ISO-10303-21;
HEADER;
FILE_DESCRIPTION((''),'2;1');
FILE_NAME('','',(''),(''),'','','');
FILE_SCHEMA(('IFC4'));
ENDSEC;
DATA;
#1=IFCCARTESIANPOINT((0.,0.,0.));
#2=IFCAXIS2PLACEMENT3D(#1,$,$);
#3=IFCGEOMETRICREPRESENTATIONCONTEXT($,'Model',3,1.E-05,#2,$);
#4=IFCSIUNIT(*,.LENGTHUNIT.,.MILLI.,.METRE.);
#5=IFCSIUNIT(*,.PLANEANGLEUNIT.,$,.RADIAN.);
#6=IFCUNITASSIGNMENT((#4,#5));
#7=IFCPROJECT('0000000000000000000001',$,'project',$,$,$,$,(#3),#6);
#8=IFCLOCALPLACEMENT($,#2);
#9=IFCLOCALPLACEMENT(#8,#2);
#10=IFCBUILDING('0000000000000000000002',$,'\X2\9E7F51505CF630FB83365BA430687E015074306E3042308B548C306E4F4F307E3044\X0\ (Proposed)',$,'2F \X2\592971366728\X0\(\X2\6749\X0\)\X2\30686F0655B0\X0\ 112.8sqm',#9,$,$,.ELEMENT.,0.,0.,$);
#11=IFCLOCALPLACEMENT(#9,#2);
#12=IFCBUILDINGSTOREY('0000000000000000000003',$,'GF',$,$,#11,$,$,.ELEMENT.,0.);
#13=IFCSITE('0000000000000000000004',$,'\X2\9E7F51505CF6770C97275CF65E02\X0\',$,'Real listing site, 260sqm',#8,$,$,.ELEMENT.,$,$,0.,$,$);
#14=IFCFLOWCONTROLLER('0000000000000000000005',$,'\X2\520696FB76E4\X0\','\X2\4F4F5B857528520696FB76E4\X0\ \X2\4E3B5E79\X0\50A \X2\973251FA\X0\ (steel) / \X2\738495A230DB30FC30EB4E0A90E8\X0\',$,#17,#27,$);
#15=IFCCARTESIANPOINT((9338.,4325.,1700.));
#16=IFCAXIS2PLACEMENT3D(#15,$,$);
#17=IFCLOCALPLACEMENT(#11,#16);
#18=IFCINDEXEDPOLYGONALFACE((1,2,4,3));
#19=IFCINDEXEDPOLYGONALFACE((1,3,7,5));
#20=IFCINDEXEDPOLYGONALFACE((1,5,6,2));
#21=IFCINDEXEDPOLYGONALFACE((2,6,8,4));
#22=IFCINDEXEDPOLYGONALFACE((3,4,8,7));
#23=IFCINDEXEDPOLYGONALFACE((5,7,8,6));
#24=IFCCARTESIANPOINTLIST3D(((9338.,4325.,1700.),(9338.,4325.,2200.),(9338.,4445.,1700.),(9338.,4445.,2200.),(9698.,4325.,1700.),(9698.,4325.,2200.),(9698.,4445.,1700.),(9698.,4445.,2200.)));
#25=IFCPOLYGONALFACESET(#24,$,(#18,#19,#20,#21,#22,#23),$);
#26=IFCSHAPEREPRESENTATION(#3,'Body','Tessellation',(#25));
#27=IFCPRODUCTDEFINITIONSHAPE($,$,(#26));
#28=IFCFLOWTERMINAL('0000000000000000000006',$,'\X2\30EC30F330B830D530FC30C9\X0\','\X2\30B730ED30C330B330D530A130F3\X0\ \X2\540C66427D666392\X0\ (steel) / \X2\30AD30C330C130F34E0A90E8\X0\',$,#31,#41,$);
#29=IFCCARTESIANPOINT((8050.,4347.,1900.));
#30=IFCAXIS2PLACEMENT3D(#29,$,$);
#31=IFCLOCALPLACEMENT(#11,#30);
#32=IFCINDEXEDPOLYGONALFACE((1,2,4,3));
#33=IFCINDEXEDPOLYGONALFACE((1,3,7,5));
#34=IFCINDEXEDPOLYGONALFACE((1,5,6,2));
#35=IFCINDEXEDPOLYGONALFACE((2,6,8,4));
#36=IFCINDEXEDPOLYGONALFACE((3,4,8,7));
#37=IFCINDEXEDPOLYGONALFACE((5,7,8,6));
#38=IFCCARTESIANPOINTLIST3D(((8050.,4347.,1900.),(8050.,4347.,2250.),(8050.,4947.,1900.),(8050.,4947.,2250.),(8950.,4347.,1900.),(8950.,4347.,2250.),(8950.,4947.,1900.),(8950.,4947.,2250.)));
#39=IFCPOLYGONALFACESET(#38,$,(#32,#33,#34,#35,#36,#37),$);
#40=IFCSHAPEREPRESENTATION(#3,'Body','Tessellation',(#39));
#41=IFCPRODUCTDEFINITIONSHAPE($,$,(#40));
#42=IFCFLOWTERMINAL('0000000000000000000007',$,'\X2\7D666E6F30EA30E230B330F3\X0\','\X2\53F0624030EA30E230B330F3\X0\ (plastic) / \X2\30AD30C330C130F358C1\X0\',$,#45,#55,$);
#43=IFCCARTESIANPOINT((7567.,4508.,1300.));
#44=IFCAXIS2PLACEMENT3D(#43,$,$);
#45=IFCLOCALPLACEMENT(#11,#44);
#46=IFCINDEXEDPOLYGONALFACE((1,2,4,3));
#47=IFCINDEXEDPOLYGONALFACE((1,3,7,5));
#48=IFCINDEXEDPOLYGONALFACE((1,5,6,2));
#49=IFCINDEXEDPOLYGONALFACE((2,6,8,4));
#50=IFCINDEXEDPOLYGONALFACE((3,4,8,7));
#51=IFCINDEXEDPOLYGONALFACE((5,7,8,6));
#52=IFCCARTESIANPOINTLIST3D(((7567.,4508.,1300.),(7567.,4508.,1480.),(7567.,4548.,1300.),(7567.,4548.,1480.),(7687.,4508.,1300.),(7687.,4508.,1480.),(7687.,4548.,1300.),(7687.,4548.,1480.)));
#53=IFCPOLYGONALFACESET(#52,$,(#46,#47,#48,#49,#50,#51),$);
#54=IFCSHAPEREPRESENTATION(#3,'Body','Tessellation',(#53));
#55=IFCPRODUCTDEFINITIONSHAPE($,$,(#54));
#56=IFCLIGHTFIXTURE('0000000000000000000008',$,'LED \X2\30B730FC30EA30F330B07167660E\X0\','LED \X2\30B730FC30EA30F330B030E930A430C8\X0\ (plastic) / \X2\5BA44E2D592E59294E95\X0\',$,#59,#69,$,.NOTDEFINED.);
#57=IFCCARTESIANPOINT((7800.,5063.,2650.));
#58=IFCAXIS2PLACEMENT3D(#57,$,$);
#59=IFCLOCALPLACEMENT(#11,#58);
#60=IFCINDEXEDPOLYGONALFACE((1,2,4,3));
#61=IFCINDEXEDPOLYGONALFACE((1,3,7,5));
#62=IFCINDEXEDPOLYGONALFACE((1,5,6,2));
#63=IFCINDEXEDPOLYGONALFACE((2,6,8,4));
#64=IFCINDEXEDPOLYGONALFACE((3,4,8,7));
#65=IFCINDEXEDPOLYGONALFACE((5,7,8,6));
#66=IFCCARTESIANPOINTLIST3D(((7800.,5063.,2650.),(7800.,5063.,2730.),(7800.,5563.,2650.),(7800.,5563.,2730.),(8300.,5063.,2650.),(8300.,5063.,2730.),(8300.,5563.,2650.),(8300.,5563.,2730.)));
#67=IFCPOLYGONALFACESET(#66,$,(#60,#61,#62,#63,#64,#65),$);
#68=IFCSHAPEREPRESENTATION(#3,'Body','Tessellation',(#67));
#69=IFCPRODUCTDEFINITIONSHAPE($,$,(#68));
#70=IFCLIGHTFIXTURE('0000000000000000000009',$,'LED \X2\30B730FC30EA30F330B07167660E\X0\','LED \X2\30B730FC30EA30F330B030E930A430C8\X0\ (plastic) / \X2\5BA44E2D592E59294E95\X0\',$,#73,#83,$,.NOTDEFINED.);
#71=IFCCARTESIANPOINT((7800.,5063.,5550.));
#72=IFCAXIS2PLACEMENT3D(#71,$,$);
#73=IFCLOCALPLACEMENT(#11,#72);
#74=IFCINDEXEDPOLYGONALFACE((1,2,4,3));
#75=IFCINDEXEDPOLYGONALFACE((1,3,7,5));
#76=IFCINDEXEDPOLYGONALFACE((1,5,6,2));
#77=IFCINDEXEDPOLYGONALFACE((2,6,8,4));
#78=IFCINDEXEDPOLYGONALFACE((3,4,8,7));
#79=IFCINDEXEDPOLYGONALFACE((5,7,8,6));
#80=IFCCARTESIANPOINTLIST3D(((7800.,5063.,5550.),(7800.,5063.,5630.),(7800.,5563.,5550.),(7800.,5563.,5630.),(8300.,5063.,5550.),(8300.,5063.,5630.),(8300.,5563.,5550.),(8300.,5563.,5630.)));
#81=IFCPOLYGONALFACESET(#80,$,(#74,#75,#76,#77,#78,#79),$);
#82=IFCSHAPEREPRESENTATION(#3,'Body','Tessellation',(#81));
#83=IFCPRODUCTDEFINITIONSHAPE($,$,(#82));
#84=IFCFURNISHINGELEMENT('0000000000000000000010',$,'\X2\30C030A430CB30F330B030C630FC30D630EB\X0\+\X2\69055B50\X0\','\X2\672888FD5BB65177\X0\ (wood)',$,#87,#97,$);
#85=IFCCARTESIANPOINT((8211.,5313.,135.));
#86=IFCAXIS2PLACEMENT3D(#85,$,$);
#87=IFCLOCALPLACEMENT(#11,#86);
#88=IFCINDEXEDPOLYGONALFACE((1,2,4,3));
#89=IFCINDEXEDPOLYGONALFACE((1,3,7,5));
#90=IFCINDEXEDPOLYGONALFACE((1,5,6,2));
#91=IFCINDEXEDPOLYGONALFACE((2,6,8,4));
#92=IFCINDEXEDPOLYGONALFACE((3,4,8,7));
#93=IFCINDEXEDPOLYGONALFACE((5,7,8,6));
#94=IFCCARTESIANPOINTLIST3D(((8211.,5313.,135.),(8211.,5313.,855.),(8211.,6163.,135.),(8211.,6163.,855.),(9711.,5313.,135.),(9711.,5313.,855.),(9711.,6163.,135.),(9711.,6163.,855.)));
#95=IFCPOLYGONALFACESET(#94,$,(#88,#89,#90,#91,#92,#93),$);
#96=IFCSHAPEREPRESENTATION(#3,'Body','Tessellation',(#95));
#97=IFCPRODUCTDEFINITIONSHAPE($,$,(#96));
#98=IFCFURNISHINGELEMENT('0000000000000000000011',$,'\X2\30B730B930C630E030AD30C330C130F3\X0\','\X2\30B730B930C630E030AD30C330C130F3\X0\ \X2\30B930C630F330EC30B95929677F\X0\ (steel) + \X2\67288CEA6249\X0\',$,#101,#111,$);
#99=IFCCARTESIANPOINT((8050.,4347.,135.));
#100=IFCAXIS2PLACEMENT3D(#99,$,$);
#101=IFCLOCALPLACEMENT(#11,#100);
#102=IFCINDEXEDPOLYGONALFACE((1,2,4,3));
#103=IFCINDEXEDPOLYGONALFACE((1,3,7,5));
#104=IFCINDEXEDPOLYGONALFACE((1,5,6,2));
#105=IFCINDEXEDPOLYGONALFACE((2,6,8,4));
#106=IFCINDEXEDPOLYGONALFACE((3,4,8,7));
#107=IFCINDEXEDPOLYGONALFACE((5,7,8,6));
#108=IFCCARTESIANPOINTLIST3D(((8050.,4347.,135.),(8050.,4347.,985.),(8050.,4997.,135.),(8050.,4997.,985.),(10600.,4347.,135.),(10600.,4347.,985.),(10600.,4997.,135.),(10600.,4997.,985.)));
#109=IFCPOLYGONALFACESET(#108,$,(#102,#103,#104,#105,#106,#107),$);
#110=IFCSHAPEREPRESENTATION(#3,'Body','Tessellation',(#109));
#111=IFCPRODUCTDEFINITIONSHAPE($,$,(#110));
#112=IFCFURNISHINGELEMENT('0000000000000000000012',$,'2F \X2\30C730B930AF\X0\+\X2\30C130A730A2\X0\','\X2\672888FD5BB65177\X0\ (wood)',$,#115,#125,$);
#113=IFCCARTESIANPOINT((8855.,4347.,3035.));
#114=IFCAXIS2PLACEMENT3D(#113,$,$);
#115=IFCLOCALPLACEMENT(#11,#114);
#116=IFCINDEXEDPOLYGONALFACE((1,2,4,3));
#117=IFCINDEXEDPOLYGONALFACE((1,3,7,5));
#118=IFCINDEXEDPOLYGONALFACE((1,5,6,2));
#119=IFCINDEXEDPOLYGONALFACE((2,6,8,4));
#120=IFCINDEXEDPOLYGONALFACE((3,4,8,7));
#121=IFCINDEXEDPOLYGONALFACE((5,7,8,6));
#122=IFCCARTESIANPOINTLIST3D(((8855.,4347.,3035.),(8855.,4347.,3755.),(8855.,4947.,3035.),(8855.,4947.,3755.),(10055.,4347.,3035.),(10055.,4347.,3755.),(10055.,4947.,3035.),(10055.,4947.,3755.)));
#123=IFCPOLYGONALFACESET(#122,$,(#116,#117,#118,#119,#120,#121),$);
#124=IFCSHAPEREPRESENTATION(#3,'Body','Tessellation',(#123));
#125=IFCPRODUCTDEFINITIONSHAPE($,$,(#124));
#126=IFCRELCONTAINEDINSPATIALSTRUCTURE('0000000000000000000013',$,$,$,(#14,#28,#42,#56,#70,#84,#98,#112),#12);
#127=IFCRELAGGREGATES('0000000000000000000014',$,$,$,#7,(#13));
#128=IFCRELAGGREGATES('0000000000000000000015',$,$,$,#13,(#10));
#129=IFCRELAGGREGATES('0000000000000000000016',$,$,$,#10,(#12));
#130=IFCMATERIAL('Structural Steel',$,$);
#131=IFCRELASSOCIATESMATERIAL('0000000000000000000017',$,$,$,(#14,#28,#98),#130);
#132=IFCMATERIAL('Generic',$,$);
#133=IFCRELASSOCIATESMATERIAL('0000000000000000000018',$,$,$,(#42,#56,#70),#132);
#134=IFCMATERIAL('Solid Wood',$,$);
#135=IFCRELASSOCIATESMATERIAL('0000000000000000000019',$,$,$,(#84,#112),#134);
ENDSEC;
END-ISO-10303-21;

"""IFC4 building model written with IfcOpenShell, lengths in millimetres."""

from ifc_helpers import new_model, si_unit, frame, frame_2d, origin, place, context, project, spatial, rectangle, extrude, material, element, save


model = new_model("IFC4")

# Units and contexts
model_context = context("Model", 3, precision=1e-05, world=origin())
ifc_project = project(units=[si_unit("LENGTHUNIT", "METRE", prefix="MILLI"), si_unit("PLANEANGLEUNIT", "RADIAN")], contexts=[model_context])

# Site, building, storey
site_placement = place(None, origin())
site = spatial("IfcSite", under=ifc_project, at=site_placement, Name="鹿児島県霧島市", ObjectType="Real listing site, 260sqm", CompositionType="ELEMENT", RefElevation=0.0)
building_placement = place(site_placement, origin())
building = spatial("IfcBuilding", under=site, at=building_placement, Name="鹿児島・茶室と縁側のある和の住まい (Proposed)", ObjectType="2F 天然木(杉)と漆喰 112.8sqm", CompositionType="ELEMENT", ElevationOfRefHeight=0.0, ElevationOfTerrain=0.0)
storey_placement = place(building_placement, origin())
storey = spatial("IfcBuildingStorey", under=building, at=storey_placement, Name="GF", CompositionType="ELEMENT", Elevation=0.0)

# Shared definitions
ifc_material_1 = material(Name="Solid Wood")

# Shared definitions
ifc_material_2 = material(Name="Structural Steel")

# Flow controller
flow_controller_placement = place(storey_placement, frame((9338.0, 4325.0, 1700.0)))
element("IfcFlowController", 1, at=flow_controller_placement, inside=storey, material=ifc_material_2, Name="分電盤", Description="住宅用分電盤 主幹50A 露出 (steel) / 玄関ホール上部", context=model_context, shape_type="SweptSolid", body=[
    extrude(rectangle(XDim=360.0, YDim=120.0, at=frame_2d((180.0, 60.0))), frame((9338.0, 4325.0, 1700.0)), (0.0, 0.0, 1.0), 500.0),
])

# Flow terminals
flow_terminal_1_placement = place(storey_placement, frame((8050.0, 4347.0, 1900.0)))
element("IfcFlowTerminal", 2, at=flow_terminal_1_placement, inside=storey, material=ifc_material_2, Name="レンジフード", Description="シロッコファン 同時給排 (steel) / キッチン上部", context=model_context, shape_type="SweptSolid", body=[
    extrude(rectangle(XDim=900.0, YDim=600.0, at=frame_2d((450.0, 300.0))), frame((8050.0, 4347.0, 1900.0)), (0.0, 0.0, 1.0), 350.0),
])
ifc_material_3 = material(Name="Generic")
flow_terminal_2_placement = place(storey_placement, frame((7567.0, 4508.0, 1300.0)))
element("IfcFlowTerminal", 3, at=flow_terminal_2_placement, inside=storey, material=ifc_material_3, Name="給湯リモコン", Description="台所リモコン (plastic) / キッチン壁", context=model_context, shape_type="SweptSolid", body=[
    extrude(rectangle(XDim=120.0, YDim=40.0, at=frame_2d((60.0, 20.0))), frame((7567.0, 4508.0, 1300.0)), (0.0, 0.0, 1.0), 180.0),
])

# Light fixtures
light_fixture_1_placement = place(storey_placement, frame((7800.0, 5063.0, 2650.0)))
element("IfcLightFixture", 4, at=light_fixture_1_placement, inside=storey, material=ifc_material_3, Name="LED シーリング照明", Description="LED シーリングライト (plastic) / 室中央天井", PredefinedType="NOTDEFINED", context=model_context, shape_type="SweptSolid", body=[
    extrude(rectangle(XDim=500.0, YDim=500.0, at=frame_2d((250.0, 250.0))), frame((7800.0, 5063.0, 2650.0)), (0.0, 0.0, 1.0), 80.0),
])
light_fixture_2_placement = place(storey_placement, frame((7800.0, 5063.0, 5550.0)))
element("IfcLightFixture", 5, at=light_fixture_2_placement, inside=storey, material=ifc_material_3, Name="LED シーリング照明", Description="LED シーリングライト (plastic) / 室中央天井", PredefinedType="NOTDEFINED", context=model_context, shape_type="SweptSolid", body=[
    extrude(rectangle(XDim=500.0, YDim=500.0, at=frame_2d((250.0, 250.0))), frame((7800.0, 5063.0, 5550.0)), (0.0, 0.0, 1.0), 80.0),
])

# Furnishing elements
furnishing_1_placement = place(storey_placement, frame((8211.0, 5313.0, 135.0)))
element("IfcFurnishingElement", 6, at=furnishing_1_placement, inside=storey, material=ifc_material_1, Name="ダイニングテーブル+椅子", Description="木製家具 (wood)", context=model_context, shape_type="SweptSolid", body=[
    extrude(rectangle(XDim=1500.0, YDim=850.0, at=frame_2d((750.0, 425.0))), frame((8211.0, 5313.0, 135.0)), (0.0, 0.0, 1.0), 720.0),
])
furnishing_2_placement = place(storey_placement, frame((8050.0, 4347.0, 135.0)))
element("IfcFurnishingElement", 7, at=furnishing_2_placement, inside=storey, material=ifc_material_2, Name="システムキッチン", Description="システムキッチン ステンレス天板 (steel) + 木質扉", context=model_context, shape_type="SweptSolid", body=[
    extrude(rectangle(XDim=2550.0, YDim=650.0, at=frame_2d((1275.0, 325.0))), frame((8050.0, 4347.0, 135.0)), (0.0, 0.0, 1.0), 850.0),
])
furnishing_3_placement = place(storey_placement, frame((8855.0, 4347.0, 3035.0)))
element("IfcFurnishingElement", 8, at=furnishing_3_placement, inside=storey, material=ifc_material_1, Name="2F デスク+チェア", Description="木製家具 (wood)", context=model_context, shape_type="SweptSolid", body=[
    extrude(rectangle(XDim=1200.0, YDim=600.0, at=frame_2d((600.0, 300.0))), frame((8855.0, 4347.0, 3035.0)), (0.0, 0.0, 1.0), 720.0),
])

save(model, "model.ifc")
